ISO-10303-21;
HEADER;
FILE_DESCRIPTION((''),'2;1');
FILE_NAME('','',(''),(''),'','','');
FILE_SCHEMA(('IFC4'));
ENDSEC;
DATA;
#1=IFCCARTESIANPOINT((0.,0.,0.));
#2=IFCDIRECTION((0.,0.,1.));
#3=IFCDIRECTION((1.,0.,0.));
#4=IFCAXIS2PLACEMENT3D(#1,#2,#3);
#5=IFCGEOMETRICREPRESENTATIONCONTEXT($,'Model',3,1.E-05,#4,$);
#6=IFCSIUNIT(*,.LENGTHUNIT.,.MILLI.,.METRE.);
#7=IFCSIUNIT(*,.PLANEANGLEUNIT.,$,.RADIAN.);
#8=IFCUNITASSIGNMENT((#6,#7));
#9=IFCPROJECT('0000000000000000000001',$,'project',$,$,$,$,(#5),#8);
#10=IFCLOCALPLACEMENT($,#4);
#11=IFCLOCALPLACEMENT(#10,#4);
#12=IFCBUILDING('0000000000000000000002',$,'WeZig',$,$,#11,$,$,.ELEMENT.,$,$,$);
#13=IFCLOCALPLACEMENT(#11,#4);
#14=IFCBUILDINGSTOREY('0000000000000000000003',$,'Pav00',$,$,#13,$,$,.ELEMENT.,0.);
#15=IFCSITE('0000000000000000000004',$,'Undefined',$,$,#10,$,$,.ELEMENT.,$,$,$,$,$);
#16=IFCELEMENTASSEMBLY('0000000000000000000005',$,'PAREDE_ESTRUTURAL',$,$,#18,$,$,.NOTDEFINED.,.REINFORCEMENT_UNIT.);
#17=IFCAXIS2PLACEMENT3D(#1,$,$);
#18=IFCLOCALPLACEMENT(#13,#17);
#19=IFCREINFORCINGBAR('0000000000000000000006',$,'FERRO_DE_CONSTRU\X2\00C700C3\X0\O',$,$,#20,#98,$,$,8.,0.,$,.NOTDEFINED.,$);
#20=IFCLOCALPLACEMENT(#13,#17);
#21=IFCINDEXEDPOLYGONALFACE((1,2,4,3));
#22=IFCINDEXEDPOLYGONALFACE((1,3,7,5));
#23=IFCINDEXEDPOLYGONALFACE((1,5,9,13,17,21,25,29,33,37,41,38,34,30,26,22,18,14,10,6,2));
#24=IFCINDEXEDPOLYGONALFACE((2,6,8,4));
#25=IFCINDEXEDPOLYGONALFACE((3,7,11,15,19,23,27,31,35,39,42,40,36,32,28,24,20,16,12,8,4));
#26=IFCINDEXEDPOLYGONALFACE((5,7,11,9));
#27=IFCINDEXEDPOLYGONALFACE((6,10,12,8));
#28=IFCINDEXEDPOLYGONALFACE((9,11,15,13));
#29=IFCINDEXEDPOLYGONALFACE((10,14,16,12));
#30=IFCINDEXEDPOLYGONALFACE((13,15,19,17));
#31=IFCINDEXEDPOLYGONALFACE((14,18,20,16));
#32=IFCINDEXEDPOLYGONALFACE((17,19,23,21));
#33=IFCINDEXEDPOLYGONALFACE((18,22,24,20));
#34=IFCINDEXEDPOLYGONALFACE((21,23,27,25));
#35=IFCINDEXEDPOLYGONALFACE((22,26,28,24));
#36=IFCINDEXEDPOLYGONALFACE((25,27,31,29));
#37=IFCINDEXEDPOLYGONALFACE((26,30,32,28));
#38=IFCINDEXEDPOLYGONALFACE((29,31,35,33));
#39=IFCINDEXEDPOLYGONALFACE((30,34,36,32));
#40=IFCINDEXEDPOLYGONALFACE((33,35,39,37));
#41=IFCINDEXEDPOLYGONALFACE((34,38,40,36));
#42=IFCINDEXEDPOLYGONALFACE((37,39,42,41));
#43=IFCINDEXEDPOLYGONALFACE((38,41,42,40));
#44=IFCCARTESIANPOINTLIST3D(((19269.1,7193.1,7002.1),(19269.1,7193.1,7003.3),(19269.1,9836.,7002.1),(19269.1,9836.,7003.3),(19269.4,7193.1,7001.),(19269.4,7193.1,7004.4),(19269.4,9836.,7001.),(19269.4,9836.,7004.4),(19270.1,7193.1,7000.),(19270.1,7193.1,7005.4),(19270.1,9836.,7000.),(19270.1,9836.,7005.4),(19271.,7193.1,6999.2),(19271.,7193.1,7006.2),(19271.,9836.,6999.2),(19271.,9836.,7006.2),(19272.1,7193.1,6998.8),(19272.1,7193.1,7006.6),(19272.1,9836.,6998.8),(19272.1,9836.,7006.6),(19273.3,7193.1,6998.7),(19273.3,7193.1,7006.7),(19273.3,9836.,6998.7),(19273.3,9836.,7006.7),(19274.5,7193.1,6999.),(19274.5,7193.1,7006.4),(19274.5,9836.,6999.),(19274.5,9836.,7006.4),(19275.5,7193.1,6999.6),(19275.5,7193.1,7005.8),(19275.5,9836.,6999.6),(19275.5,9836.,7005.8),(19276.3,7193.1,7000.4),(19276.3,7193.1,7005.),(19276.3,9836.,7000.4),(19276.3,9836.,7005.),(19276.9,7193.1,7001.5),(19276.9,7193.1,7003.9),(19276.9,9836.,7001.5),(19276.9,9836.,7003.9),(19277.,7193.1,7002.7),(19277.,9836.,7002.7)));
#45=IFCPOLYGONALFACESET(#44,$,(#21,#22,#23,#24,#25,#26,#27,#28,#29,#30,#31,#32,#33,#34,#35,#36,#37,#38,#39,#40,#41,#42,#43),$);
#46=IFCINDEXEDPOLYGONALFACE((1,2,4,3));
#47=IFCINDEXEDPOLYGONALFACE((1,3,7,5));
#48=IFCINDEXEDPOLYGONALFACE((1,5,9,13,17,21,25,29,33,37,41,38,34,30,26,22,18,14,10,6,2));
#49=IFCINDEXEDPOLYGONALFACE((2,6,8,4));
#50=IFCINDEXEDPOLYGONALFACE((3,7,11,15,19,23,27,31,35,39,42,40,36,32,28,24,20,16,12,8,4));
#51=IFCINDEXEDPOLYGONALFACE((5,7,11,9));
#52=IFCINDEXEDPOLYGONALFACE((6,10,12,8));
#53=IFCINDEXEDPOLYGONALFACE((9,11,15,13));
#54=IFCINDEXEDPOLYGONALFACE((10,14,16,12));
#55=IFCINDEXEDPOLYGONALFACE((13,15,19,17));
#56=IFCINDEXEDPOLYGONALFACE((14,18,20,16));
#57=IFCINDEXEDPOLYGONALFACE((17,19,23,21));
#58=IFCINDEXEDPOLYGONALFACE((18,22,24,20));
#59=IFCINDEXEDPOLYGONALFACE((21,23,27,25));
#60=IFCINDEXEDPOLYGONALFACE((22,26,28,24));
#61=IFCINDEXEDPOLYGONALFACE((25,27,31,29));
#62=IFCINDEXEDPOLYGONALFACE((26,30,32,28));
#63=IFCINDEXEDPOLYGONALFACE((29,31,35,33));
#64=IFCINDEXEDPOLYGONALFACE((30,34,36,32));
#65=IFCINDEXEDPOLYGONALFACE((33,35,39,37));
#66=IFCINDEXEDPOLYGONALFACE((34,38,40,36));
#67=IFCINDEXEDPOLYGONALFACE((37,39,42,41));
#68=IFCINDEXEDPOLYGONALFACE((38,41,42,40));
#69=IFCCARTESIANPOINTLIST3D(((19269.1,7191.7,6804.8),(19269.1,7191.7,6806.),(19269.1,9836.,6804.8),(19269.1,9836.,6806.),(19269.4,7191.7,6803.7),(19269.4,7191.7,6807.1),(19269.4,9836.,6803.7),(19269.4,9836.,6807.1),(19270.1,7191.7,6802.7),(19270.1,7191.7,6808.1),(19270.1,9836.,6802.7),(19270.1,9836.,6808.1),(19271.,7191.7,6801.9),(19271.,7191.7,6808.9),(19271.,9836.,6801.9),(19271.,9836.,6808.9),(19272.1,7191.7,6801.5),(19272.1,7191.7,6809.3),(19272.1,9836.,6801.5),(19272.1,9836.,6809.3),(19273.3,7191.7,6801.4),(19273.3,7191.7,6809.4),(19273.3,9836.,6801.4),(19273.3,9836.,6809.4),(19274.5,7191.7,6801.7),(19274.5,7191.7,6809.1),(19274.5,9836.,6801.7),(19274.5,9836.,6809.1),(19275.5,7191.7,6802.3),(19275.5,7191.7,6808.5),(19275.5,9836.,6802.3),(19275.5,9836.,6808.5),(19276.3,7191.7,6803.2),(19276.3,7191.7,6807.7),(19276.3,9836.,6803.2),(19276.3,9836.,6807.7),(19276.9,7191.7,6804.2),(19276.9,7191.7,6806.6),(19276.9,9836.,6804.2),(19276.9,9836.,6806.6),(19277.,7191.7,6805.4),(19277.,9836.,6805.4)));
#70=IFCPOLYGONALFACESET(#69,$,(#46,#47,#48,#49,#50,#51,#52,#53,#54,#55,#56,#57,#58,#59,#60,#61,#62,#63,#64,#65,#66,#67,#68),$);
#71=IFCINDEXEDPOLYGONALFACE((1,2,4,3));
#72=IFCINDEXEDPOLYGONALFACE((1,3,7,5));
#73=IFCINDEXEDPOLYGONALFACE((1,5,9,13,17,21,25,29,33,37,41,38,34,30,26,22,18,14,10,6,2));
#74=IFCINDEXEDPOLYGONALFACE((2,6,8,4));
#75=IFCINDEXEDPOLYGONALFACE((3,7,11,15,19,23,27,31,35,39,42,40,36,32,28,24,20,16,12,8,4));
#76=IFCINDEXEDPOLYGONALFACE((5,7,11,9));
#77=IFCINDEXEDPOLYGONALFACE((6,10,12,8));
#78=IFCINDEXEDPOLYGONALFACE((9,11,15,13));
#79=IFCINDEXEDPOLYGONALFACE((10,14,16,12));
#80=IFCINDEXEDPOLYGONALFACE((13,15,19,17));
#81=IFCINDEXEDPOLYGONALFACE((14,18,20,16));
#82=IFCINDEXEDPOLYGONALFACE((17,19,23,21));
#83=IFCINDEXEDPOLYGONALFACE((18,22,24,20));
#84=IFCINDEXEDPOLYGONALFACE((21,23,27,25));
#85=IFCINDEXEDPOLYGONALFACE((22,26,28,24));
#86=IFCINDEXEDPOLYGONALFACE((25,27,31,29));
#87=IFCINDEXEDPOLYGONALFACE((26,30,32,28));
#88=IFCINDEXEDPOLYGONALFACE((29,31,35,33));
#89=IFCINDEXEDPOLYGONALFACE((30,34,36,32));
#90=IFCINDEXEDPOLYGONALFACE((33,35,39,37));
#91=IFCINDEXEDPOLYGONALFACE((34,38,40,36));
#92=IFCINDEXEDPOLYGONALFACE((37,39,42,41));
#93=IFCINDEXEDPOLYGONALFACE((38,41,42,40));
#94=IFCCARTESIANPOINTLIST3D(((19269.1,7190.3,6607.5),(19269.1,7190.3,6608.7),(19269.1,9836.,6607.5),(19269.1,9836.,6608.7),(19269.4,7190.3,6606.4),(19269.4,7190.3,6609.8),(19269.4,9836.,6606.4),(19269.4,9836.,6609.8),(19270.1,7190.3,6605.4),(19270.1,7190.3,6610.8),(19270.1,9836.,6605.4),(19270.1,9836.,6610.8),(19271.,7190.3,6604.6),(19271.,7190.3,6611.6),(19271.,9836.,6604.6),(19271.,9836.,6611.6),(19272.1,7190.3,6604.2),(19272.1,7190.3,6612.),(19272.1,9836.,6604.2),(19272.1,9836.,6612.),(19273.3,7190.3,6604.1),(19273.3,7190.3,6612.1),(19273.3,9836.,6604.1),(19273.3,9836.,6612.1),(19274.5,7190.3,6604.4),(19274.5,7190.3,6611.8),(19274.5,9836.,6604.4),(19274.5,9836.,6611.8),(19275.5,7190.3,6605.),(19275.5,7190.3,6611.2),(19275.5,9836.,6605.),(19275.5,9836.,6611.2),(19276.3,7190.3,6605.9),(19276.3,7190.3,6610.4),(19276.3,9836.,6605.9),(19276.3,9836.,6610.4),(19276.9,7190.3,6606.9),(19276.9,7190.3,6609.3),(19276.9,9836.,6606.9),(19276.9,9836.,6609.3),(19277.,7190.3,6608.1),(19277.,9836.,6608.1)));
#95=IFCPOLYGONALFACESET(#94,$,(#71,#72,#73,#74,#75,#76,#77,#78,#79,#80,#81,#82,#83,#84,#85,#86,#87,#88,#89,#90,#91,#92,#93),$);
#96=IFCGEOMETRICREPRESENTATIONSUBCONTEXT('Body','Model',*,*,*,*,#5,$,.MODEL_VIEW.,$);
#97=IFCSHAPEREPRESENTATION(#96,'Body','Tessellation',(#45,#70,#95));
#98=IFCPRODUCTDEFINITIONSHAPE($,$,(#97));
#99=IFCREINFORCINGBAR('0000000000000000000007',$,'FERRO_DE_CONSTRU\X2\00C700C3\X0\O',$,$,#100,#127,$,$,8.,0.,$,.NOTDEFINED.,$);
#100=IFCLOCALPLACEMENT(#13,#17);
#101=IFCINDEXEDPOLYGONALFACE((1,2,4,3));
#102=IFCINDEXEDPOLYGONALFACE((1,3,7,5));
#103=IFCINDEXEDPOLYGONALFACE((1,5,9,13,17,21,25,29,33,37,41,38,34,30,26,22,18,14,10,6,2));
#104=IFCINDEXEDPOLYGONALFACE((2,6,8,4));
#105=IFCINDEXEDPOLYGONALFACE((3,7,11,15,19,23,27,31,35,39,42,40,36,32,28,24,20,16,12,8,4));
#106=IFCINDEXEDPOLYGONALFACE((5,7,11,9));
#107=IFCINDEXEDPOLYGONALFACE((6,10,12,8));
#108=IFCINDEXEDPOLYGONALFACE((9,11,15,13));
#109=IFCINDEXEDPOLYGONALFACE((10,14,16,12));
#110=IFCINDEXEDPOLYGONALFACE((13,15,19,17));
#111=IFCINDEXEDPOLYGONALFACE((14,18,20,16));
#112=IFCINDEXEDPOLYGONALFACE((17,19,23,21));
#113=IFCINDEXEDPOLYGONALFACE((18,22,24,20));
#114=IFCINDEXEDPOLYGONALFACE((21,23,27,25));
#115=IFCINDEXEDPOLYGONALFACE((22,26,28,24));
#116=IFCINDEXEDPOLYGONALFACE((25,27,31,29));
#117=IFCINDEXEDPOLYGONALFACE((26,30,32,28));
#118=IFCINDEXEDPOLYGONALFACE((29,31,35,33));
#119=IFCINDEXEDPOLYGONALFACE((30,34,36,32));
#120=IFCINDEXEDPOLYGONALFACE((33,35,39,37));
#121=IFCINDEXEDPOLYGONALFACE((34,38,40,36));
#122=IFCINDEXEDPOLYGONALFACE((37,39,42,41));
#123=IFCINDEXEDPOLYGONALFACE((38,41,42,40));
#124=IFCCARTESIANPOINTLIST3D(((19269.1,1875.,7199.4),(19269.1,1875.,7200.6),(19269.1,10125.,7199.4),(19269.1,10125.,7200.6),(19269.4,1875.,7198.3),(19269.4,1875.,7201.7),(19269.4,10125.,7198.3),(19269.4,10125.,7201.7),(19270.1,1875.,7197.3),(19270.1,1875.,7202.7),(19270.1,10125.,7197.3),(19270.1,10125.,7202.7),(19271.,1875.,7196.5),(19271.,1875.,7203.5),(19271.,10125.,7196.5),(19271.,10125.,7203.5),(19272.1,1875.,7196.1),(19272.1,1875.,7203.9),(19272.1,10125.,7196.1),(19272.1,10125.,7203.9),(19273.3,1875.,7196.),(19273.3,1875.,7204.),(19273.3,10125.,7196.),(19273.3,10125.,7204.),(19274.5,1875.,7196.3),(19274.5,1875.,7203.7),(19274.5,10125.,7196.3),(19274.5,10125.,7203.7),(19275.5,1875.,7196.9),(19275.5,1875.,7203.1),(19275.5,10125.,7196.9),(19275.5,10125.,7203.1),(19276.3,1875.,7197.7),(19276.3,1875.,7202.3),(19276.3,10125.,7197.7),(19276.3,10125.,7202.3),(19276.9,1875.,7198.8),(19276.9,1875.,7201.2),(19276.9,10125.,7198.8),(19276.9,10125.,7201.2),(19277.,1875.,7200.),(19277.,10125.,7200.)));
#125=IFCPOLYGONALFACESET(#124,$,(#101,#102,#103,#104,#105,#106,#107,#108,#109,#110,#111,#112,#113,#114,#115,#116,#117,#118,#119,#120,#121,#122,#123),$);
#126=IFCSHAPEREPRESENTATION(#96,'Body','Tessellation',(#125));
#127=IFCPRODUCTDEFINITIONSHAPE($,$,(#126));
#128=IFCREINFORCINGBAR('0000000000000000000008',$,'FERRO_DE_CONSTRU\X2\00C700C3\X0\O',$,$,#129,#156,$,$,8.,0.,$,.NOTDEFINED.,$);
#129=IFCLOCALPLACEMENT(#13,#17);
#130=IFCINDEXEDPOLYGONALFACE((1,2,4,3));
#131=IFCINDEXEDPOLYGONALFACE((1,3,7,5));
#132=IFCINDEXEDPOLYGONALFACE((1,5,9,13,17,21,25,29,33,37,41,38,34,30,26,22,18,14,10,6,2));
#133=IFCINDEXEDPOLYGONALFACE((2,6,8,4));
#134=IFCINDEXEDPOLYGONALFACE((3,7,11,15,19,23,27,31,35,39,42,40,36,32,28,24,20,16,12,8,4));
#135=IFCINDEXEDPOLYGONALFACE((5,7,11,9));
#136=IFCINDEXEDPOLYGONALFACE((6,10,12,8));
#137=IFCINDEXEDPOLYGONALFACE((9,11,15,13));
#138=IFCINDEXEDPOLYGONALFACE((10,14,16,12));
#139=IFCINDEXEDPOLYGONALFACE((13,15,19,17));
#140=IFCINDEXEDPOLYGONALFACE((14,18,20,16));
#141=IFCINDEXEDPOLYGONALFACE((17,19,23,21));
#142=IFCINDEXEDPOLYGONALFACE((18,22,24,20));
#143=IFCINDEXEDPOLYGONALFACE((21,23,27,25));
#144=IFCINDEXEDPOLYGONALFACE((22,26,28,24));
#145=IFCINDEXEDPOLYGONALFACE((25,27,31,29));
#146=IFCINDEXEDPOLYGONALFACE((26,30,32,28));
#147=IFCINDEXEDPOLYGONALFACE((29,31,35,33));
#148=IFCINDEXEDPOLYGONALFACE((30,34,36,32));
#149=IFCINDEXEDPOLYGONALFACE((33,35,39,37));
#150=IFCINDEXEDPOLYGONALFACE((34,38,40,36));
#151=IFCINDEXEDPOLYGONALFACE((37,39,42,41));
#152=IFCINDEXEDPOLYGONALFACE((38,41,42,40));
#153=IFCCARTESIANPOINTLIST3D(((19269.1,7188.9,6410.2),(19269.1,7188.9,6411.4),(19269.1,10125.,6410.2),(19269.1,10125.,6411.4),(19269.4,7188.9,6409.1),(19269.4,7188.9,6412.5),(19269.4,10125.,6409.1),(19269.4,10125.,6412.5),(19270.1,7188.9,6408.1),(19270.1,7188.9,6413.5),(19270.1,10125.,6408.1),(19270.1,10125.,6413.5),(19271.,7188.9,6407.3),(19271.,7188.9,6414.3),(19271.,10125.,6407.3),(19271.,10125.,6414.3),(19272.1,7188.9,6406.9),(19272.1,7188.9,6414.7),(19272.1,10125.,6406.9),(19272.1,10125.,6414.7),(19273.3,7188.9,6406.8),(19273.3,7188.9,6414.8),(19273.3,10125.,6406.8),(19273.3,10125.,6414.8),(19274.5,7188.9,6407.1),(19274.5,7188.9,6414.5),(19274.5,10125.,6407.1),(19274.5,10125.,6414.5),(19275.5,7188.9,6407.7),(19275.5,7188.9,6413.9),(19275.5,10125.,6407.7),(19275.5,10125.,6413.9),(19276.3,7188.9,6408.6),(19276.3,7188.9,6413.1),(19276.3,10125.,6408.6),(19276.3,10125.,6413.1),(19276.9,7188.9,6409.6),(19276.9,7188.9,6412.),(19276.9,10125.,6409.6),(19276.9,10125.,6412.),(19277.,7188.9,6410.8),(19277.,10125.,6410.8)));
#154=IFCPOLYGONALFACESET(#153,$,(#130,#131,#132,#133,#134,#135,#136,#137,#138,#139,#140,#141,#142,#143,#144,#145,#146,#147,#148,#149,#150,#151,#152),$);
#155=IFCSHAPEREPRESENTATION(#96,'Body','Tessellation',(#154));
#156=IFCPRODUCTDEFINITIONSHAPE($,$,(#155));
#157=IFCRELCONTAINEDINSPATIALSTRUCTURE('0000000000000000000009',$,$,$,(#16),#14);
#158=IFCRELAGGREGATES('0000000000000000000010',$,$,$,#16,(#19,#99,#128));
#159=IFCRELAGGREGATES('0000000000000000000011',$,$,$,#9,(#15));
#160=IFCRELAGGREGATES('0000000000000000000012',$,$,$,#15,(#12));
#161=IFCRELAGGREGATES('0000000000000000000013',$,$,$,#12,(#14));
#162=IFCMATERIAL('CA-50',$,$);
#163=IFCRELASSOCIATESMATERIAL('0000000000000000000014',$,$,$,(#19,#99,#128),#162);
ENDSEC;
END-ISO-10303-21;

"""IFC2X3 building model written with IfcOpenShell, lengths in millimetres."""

from ifc_helpers import new_model, entity, si_unit, frame, origin_with_axes, place, context, subcontext, project, spatial, source, transform, mapped, material, element, aggregate, save


model = new_model("IFC2X3")

# Units and contexts
model_context = context("Model", 3, precision=1e-05, world=origin_with_axes())
body_context = subcontext(model_context, "Body", "Model", "MODEL_VIEW")
ifc_project = project(units=[si_unit("LENGTHUNIT", "METRE", prefix="MILLI"), si_unit("PLANEANGLEUNIT", "RADIAN")], contexts=[model_context])

# Site, building, storey
site_placement = place(None, origin_with_axes())
site = spatial("IfcSite", under=ifc_project, at=site_placement, Name="Undefined", CompositionType="ELEMENT")
building_placement = place(site_placement, origin_with_axes())
building = spatial("IfcBuilding", under=site, at=building_placement, Name="WeZig", CompositionType="ELEMENT")
storey_placement = place(building_placement, origin_with_axes())
storey = spatial("IfcBuildingStorey", under=building, at=storey_placement, Name="Pav00", CompositionType="ELEMENT", Elevation=0.0)

# Element assembly
assembly_1_placement = place(storey_placement, origin_with_axes())
assembly_1 = element("IfcElementAssembly", 1, at=assembly_1_placement, inside=storey, Name="PAREDE_ESTRUTURAL", AssemblyPlace="NOTDEFINED", PredefinedType="REINFORCEMENT_UNIT")

# Reinforcing bars
ifc_material_1 = material(Name="CA-50")
shared_shape_1 = source(origin_with_axes(), body_context, "Body", "AdvancedSweptSolid", [
    entity("IfcSweptDiskSolid", entity("IfcTrimmedCurve", entity("IfcLine", entity("IfcCartesianPoint", [0.0, 0.0, 0.0]), entity("IfcVector", entity("IfcDirection", [1.0, 0.0, 0.0]), 1.0)), [entity("IfcParameterValue", 0.0)], [entity("IfcParameterValue", 2642.85726)], True, "PARAMETER"), 4.0, None, 0.0, 2642.9),
])
shared_shape_2 = source(origin_with_axes(), body_context, "Body", "AdvancedSweptSolid", [
    entity("IfcSweptDiskSolid", entity("IfcTrimmedCurve", entity("IfcLine", entity("IfcCartesianPoint", [0.0, 0.0, 0.0]), entity("IfcVector", entity("IfcDirection", [1.0, 0.0, 0.0]), 1.0)), [entity("IfcParameterValue", 0.0)], [entity("IfcParameterValue", 2644.270907)], True, "PARAMETER"), 4.0, None, 0.0, 2644.3),
])
shared_shape_3 = source(origin_with_axes(), body_context, "Body", "AdvancedSweptSolid", [
    entity("IfcSweptDiskSolid", entity("IfcTrimmedCurve", entity("IfcLine", entity("IfcCartesianPoint", [0.0, 0.0, 0.0]), entity("IfcVector", entity("IfcDirection", [1.0, 0.0, 0.0]), 1.0)), [entity("IfcParameterValue", 0.0)], [entity("IfcParameterValue", 2645.684554)], True, "PARAMETER"), 4.0, None, 0.0, 2645.7),
])
reinforcing_bar_1_placement = place(assembly_1_placement, frame((19273.0, 9836.0, 7002.7), z_axis=(1.0, 0.0, 0.0), x_axis=(0.0, -1.0, 0.0)))
reinforcing_bar_1 = element("IfcReinforcingBar", 2, at=reinforcing_bar_1_placement, material=ifc_material_1, Name="FERRO_DE_CONSTRUÇÃO", BarRole="NOTDEFINED", CrossSectionArea=0.0, NominalDiameter=8.0, context=body_context, shape_type="MappedRepresentation", body=[
    mapped(shared_shape_1, transform((0.0, 0.0, 0.0))),
    mapped(shared_shape_2, transform((0.0, 197.3, 0.0))),
    mapped(shared_shape_3, transform((0.0, 394.6, 0.0))),
])
shared_shape_4 = source(origin_with_axes(), body_context, "Body", "AdvancedSweptSolid", [
    entity("IfcSweptDiskSolid", entity("IfcTrimmedCurve", entity("IfcLine", entity("IfcCartesianPoint", [0.0, 0.0, 0.0]), entity("IfcVector", entity("IfcDirection", [1.0, 0.0, 0.0]), 1.0)), [entity("IfcParameterValue", 0.0)], [entity("IfcParameterValue", 8249.998938)], True, "PARAMETER"), 4.0, None, 0.0, 8250.0),
])
reinforcing_bar_2_placement = place(assembly_1_placement, frame((19273.0, 10125.0, 7200.0), z_axis=(1.0, 0.0, 0.0), x_axis=(0.0, -1.0, 0.0)))
reinforcing_bar_2 = element("IfcReinforcingBar", 3, at=reinforcing_bar_2_placement, material=ifc_material_1, Name="FERRO_DE_CONSTRUÇÃO", BarRole="NOTDEFINED", CrossSectionArea=0.0, NominalDiameter=8.0, context=body_context, shape_type="MappedRepresentation", body=[
    mapped(shared_shape_4, transform((0.0, 0.0, 0.0))),
])
shared_shape_5 = source(origin_with_axes(), body_context, "Body", "AdvancedSweptSolid", [
    entity("IfcSweptDiskSolid", entity("IfcTrimmedCurve", entity("IfcLine", entity("IfcCartesianPoint", [0.0, 0.0, 0.0]), entity("IfcVector", entity("IfcDirection", [1.0, 0.0, 0.0]), 1.0)), [entity("IfcParameterValue", 0.0)], [entity("IfcParameterValue", 2936.100128)], True, "PARAMETER"), 4.0, None, 0.0, 2936.1),
])
reinforcing_bar_3_placement = place(assembly_1_placement, frame((19273.0, 10125.0, 6410.8), z_axis=(1.0, 0.0, 0.0), x_axis=(0.0, -1.0, 0.0)))
reinforcing_bar_3 = element("IfcReinforcingBar", 4, at=reinforcing_bar_3_placement, material=ifc_material_1, Name="FERRO_DE_CONSTRUÇÃO", BarRole="NOTDEFINED", CrossSectionArea=0.0, NominalDiameter=8.0, context=body_context, shape_type="MappedRepresentation", body=[
    mapped(shared_shape_5, transform((0.0, 0.0, 0.0))),
])
aggregate(assembly_1, [reinforcing_bar_1, reinforcing_bar_2, reinforcing_bar_3])

save(model, "model.ifc")
